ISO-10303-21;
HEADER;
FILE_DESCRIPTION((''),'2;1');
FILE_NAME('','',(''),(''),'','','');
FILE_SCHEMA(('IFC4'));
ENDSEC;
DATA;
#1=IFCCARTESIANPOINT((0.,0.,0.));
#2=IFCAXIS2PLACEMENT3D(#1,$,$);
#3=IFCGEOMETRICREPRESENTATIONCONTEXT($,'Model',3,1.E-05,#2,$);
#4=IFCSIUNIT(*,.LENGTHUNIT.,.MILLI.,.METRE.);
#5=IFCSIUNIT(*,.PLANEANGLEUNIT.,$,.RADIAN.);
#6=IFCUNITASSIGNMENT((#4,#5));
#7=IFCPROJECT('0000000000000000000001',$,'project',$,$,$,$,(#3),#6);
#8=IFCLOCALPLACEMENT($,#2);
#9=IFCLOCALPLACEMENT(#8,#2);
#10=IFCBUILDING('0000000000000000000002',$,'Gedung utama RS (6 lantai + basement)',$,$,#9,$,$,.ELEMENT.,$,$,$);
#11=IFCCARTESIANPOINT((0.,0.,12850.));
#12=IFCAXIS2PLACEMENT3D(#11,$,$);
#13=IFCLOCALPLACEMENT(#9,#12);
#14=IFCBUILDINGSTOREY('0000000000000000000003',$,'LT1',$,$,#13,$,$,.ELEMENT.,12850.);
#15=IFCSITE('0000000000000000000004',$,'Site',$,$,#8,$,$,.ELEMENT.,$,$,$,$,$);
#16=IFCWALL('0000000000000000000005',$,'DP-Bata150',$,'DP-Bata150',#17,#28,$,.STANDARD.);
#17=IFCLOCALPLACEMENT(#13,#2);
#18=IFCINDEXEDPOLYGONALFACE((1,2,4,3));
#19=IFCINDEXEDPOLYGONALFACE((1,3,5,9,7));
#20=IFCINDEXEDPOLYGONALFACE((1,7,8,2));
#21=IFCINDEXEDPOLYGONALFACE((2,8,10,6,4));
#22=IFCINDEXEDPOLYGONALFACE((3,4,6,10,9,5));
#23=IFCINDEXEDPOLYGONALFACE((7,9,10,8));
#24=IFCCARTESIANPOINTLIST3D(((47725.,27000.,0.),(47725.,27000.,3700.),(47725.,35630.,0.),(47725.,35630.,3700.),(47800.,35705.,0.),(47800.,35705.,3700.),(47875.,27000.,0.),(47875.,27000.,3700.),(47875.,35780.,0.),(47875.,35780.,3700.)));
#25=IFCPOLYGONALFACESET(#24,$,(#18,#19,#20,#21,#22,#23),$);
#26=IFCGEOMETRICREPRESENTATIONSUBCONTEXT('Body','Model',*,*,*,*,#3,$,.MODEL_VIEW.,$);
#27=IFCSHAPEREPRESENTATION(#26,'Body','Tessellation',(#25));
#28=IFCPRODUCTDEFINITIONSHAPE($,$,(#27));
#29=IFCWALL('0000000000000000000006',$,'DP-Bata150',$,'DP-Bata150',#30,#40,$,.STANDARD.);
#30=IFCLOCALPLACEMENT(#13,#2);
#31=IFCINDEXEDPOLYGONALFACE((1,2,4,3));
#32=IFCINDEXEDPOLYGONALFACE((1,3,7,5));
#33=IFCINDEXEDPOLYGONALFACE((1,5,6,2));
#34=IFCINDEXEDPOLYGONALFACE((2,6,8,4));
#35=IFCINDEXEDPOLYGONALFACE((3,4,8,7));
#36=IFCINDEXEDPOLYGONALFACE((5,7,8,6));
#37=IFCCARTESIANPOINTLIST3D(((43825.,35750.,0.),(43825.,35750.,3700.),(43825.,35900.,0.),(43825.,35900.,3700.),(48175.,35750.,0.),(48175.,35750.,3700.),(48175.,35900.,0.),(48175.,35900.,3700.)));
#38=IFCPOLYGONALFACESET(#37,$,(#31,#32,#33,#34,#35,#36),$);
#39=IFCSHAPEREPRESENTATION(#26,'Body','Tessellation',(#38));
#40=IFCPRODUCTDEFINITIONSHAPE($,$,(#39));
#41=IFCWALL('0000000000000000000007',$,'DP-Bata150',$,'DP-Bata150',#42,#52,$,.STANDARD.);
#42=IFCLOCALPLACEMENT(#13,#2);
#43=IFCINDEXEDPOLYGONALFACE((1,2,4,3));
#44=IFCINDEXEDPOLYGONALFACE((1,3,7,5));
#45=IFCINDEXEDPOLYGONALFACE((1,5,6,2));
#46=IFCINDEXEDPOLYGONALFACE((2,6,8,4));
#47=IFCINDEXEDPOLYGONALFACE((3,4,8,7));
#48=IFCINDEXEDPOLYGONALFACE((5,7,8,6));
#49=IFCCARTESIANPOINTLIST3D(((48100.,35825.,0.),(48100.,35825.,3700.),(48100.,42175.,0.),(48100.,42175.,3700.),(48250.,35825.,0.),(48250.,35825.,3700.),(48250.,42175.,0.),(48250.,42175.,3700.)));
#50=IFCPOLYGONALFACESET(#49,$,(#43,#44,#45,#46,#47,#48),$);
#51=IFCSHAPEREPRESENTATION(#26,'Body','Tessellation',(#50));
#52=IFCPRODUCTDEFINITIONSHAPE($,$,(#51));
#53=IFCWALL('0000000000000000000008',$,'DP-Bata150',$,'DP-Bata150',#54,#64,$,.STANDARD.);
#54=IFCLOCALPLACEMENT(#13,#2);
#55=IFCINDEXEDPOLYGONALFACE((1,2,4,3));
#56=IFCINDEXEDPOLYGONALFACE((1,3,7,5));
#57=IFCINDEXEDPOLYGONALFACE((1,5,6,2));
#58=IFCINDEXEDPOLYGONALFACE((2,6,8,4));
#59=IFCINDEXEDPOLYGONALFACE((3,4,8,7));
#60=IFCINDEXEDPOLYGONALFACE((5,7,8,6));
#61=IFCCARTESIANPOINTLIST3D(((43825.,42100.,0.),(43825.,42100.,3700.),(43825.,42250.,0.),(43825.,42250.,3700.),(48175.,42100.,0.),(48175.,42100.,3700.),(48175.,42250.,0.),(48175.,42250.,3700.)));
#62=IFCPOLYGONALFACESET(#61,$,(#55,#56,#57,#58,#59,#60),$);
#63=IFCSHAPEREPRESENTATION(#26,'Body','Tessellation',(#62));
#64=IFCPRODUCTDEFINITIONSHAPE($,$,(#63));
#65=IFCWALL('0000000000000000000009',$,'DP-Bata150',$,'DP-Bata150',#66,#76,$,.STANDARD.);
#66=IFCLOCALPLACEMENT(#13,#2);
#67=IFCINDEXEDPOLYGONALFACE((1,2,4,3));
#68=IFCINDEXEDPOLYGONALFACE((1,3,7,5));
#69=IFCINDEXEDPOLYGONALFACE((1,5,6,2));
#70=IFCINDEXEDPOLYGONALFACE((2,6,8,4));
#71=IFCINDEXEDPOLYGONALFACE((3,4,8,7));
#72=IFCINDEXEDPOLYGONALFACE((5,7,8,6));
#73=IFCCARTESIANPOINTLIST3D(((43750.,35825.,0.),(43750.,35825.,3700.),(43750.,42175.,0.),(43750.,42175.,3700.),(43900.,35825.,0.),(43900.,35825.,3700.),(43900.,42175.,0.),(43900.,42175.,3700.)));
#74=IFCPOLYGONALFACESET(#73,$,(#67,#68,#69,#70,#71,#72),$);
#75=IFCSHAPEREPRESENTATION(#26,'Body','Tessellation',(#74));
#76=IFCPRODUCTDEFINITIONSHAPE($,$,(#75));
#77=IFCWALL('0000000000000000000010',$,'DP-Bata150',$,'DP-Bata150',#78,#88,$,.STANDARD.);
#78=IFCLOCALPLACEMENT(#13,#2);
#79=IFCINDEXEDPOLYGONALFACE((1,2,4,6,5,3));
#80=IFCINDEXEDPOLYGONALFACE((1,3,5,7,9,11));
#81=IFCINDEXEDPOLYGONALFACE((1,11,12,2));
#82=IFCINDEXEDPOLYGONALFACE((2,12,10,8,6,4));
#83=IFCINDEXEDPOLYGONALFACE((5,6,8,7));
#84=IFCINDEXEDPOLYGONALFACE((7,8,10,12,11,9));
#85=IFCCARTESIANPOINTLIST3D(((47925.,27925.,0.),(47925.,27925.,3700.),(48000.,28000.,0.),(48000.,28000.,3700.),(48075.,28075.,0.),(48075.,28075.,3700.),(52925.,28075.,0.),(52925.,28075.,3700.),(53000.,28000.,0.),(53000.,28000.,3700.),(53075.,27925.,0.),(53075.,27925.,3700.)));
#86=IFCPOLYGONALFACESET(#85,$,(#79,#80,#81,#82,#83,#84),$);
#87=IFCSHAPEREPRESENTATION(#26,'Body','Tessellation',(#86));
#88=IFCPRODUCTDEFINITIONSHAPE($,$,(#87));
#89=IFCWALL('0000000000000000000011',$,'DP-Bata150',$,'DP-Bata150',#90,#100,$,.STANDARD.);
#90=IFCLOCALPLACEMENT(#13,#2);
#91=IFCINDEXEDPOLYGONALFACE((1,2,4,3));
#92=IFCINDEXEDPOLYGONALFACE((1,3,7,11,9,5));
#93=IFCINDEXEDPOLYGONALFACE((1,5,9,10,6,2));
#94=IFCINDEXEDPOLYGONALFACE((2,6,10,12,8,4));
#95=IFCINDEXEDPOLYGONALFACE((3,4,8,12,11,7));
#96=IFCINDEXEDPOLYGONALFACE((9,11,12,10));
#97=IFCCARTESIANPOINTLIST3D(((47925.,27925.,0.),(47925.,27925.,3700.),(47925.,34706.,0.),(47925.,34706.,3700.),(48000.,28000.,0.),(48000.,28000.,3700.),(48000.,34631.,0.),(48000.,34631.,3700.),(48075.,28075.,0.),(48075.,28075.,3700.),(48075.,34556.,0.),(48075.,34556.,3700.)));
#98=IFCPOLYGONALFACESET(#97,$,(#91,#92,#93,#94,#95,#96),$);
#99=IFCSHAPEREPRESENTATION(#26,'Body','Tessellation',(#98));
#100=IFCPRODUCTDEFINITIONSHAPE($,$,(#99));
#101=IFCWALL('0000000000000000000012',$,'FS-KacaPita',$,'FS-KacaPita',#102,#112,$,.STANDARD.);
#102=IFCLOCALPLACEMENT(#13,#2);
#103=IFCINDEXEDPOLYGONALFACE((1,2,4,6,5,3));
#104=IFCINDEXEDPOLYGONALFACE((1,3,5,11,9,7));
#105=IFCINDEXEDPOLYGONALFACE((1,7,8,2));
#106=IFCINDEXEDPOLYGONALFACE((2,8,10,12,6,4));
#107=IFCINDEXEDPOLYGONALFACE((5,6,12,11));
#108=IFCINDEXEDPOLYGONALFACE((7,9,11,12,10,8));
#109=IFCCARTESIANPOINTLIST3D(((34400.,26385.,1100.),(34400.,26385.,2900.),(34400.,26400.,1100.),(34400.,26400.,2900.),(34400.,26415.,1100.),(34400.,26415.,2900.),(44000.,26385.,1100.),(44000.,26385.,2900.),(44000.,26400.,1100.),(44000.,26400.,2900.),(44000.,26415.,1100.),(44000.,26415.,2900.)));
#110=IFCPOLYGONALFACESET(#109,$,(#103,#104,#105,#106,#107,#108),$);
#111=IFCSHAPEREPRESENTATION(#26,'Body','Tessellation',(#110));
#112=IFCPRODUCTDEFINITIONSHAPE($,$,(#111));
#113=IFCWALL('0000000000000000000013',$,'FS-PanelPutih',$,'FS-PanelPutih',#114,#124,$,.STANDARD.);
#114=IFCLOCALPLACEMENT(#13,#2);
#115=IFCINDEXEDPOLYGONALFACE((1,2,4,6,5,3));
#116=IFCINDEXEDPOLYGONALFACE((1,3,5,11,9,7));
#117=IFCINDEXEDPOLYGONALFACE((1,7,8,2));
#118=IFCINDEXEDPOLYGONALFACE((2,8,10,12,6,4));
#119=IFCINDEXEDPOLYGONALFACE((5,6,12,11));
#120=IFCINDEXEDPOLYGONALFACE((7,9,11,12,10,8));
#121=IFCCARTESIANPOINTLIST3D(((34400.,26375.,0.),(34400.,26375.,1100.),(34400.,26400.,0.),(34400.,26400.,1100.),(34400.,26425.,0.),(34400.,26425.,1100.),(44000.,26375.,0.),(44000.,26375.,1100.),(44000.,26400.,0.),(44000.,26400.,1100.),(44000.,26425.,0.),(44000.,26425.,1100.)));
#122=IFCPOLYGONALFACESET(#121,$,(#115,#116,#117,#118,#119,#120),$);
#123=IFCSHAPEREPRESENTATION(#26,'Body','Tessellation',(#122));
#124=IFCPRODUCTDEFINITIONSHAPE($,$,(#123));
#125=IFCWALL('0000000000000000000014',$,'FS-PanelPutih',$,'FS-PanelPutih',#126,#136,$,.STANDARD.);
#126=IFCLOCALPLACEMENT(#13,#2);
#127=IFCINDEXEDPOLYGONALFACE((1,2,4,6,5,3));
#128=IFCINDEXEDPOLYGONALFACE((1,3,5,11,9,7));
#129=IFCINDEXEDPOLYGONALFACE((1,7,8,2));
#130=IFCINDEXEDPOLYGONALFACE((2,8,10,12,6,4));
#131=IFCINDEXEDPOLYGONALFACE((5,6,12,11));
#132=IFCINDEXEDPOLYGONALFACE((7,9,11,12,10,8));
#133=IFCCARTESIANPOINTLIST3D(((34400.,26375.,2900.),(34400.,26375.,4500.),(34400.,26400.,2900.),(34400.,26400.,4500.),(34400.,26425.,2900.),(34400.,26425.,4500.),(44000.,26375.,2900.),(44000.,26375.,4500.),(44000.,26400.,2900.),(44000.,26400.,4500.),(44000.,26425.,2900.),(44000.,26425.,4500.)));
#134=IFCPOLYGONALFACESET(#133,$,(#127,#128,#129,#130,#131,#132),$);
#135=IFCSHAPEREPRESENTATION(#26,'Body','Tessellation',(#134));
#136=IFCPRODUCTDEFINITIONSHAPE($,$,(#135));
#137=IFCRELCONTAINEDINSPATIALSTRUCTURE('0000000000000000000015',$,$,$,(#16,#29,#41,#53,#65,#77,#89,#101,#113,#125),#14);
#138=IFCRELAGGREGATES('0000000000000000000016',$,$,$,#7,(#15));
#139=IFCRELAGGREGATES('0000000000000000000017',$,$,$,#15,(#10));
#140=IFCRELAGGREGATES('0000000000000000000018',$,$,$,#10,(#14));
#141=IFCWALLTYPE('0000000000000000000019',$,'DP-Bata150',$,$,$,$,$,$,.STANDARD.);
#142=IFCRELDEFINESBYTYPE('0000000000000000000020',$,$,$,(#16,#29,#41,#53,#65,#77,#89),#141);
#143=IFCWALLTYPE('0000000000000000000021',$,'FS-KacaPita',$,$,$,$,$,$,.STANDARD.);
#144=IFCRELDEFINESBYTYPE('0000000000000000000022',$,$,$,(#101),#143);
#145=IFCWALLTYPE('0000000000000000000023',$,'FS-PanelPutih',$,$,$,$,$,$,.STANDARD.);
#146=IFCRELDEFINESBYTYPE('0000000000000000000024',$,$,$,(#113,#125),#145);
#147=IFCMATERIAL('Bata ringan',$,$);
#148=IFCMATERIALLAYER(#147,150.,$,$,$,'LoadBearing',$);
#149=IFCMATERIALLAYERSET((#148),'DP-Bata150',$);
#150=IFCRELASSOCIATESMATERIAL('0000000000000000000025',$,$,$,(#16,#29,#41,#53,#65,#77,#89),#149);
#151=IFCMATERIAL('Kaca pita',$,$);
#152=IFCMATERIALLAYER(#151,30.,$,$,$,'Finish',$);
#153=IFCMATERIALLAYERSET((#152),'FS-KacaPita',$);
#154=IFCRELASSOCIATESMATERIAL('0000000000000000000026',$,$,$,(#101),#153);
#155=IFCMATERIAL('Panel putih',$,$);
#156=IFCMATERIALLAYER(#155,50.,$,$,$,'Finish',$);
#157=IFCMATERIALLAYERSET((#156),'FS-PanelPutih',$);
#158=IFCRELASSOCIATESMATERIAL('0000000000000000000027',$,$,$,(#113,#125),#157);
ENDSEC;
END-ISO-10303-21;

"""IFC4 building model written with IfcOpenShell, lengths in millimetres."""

from ifc_helpers import new_model, si_unit, frame, origin, place, context, subcontext, project, spatial, polyline, outline, extrude, material, layer, layer_set, layer_usage, type_object, element, save


model = new_model("IFC4")

# Units and contexts
model_context = context("Model", 3, precision=1e-05, world=origin())
body_context = subcontext(model_context, "Body", "Model", "MODEL_VIEW")
ifc_project = project(units=[si_unit("LENGTHUNIT", "METRE", prefix="MILLI"), si_unit("PLANEANGLEUNIT", "RADIAN")], contexts=[model_context])

# Site, building, storey
site_placement = place(None, origin())
site = spatial("IfcSite", under=ifc_project, at=site_placement, Name="Site", CompositionType="ELEMENT")
building_placement = place(site_placement, origin())
building = spatial("IfcBuilding", under=site, at=building_placement, Name="Gedung utama RS (6 lantai + basement)", CompositionType="ELEMENT")
storey_placement = place(building_placement, frame((0.0, 0.0, 12850.0)))
storey = spatial("IfcBuildingStorey", under=building, at=storey_placement, Name="LT1", CompositionType="ELEMENT", Elevation=12850.0)

# Shared definitions
ifc_material_1 = material(Name="Bata ringan")
ifc_layer_1 = layer(ifc_material_1, 150.0, Category="LoadBearing")
ifc_layer_set_1 = layer_set([ifc_layer_1], Name="DP-Bata150")
ifc_layer_usage_1 = layer_usage(ifc_layer_set_1, "AXIS2", "NEGATIVE", 75.0)
wall_type_1 = type_object("IfcWallType", Name="DP-Bata150", PredefinedType="STANDARD")

# Walls
wall_1_placement = place(storey_placement, frame((47800.0, 35705.0, 0.0), z_axis=(0.0, 0.0, 1.0), x_axis=(0.0, -1.0, 0.0)))
element("IfcWall", 1, at=wall_1_placement, inside=storey, type_object=wall_type_1, material=ifc_layer_usage_1, Name="DP-Bata150", ObjectType="DP-Bata150", PredefinedType="STANDARD", context=body_context, shape_type="SweptSolid", body=[
    extrude(outline(polyline([(75.0, -75.0), (0.0, 0.0), (-75.0, 75.0), (8705.0, 75.0), (8705.0, -75.0), (75.0, -75.0)])), origin(), (0.0, 0.0, 1.0), 3700.0),
])
wall_2_placement = place(storey_placement, frame((43825.0, 35825.0, 0.0), z_axis=(0.0, 0.0, 1.0), x_axis=(1.0, 0.0, 0.0)))
element("IfcWall", 2, at=wall_2_placement, inside=storey, type_object=wall_type_1, material=ifc_layer_usage_1, Name="DP-Bata150", ObjectType="DP-Bata150", PredefinedType="STANDARD", context=body_context, shape_type="SweptSolid", body=[
    extrude(outline(polyline([(0.0, -75.0), (0.0, 75.0), (4350.0, 75.0), (4350.0, -75.0), (0.0, -75.0)])), origin(), (0.0, 0.0, 1.0), 3700.0),
])
wall_3_placement = place(storey_placement, frame((48175.0, 35825.0, 0.0), z_axis=(0.0, 0.0, 1.0), x_axis=(0.0, 1.0, 0.0)))
element("IfcWall", 3, at=wall_3_placement, inside=storey, type_object=wall_type_1, material=ifc_layer_usage_1, Name="DP-Bata150", ObjectType="DP-Bata150", PredefinedType="STANDARD", context=body_context, shape_type="SweptSolid", body=[
    extrude(outline(polyline([(0.0, -75.0), (0.0, 75.0), (6350.0, 75.0), (6350.0, -75.0), (0.0, -75.0)])), origin(), (0.0, 0.0, 1.0), 3700.0),
])
wall_4_placement = place(storey_placement, frame((48175.0, 42175.0, 0.0), z_axis=(0.0, 0.0, 1.0), x_axis=(-1.0, 0.0, 0.0)))
element("IfcWall", 4, at=wall_4_placement, inside=storey, type_object=wall_type_1, material=ifc_layer_usage_1, Name="DP-Bata150", ObjectType="DP-Bata150", PredefinedType="STANDARD", context=body_context, shape_type="SweptSolid", body=[
    extrude(outline(polyline([(0.0, -75.0), (0.0, 75.0), (4350.0, 75.0), (4350.0, -75.0), (0.0, -75.0)])), origin(), (0.0, 0.0, 1.0), 3700.0),
])
wall_5_placement = place(storey_placement, frame((43825.0, 42175.0, 0.0), z_axis=(0.0, 0.0, 1.0), x_axis=(0.0, -1.0, 0.0)))
element("IfcWall", 5, at=wall_5_placement, inside=storey, type_object=wall_type_1, material=ifc_layer_usage_1, Name="DP-Bata150", ObjectType="DP-Bata150", PredefinedType="STANDARD", context=body_context, shape_type="SweptSolid", body=[
    extrude(outline(polyline([(0.0, -75.0), (0.0, 75.0), (6350.0, 75.0), (6350.0, -75.0), (0.0, -75.0)])), origin(), (0.0, 0.0, 1.0), 3700.0),
])
wall_6_placement = place(storey_placement, frame((48000.0, 28000.0, 0.0), z_axis=(0.0, 0.0, 1.0), x_axis=(1.0, 0.0, 0.0)))
element("IfcWall", 6, at=wall_6_placement, inside=storey, type_object=wall_type_1, material=ifc_layer_usage_1, Name="DP-Bata150", ObjectType="DP-Bata150", PredefinedType="STANDARD", context=body_context, shape_type="SweptSolid", body=[
    extrude(outline(polyline([(-75.0, -75.0), (0.0, 0.0), (75.0, 75.0), (4925.0, 75.0), (5000.0, 0.0), (5075.0, -75.0), (-75.0, -75.0)])), origin(), (0.0, 0.0, 1.0), 3700.0),
])
wall_7_placement = place(storey_placement, frame((48000.0, 34631.0, 0.0), z_axis=(0.0, 0.0, 1.0), x_axis=(0.0, -1.0, 0.0)))
element("IfcWall", 7, at=wall_7_placement, inside=storey, type_object=wall_type_1, material=ifc_layer_usage_1, Name="DP-Bata150", ObjectType="DP-Bata150", PredefinedType="STANDARD", context=body_context, shape_type="SweptSolid", body=[
    extrude(outline(polyline([(-75.0, -75.0), (0.0, 0.0), (75.0, 75.0), (6556.0, 75.0), (6631.0, 0.0), (6706.0, -75.0), (-75.0, -75.0)])), origin(), (0.0, 0.0, 1.0), 3700.0),
])
ifc_material_2 = material(Name="Kaca pita")
ifc_layer_2 = layer(ifc_material_2, 30.0, Category="Finish")
ifc_layer_set_2 = layer_set([ifc_layer_2], Name="FS-KacaPita")
ifc_layer_usage_2 = layer_usage(ifc_layer_set_2, "AXIS2", "NEGATIVE", 15.0)
wall_type_2 = type_object("IfcWallType", Name="FS-KacaPita", PredefinedType="STANDARD")
wall_8_placement = place(storey_placement, frame((44000.0, 26400.0, 1100.0), z_axis=(0.0, 0.0, 1.0), x_axis=(-1.0, 0.0, 0.0)))
element("IfcWall", 8, at=wall_8_placement, inside=storey, type_object=wall_type_2, material=ifc_layer_usage_2, Name="FS-KacaPita", ObjectType="FS-KacaPita", PredefinedType="STANDARD", context=body_context, shape_type="SweptSolid", body=[
    extrude(outline(polyline([(0.0, -15.0), (0.0, 0.0), (0.0, 15.0), (9600.0, 15.0), (9600.0, 0.0), (9600.0, -15.0), (0.0, -15.0)])), origin(), (0.0, 0.0, 1.0), 1800.0),
])
ifc_material_3 = material(Name="Panel putih")
ifc_layer_3 = layer(ifc_material_3, 50.0, Category="Finish")
ifc_layer_set_3 = layer_set([ifc_layer_3], Name="FS-PanelPutih")
ifc_layer_usage_3 = layer_usage(ifc_layer_set_3, "AXIS2", "NEGATIVE", 25.0)
wall_type_3 = type_object("IfcWallType", Name="FS-PanelPutih", PredefinedType="STANDARD")
wall_9_placement = place(storey_placement, frame((44000.0, 26400.0, 0.0), z_axis=(0.0, 0.0, 1.0), x_axis=(-1.0, 0.0, 0.0)))
element("IfcWall", 9, at=wall_9_placement, inside=storey, type_object=wall_type_3, material=ifc_layer_usage_3, Name="FS-PanelPutih", ObjectType="FS-PanelPutih", PredefinedType="STANDARD", context=body_context, shape_type="SweptSolid", body=[
    extrude(outline(polyline([(0.0, -25.0), (0.0, 0.0), (0.0, 25.0), (9600.0, 25.0), (9600.0, 0.0), (9600.0, -25.0), (0.0, -25.0)])), origin(), (0.0, 0.0, 1.0), 1100.0),
])
wall_10_placement = place(storey_placement, frame((44000.0, 26400.0, 2900.0), z_axis=(0.0, 0.0, 1.0), x_axis=(-1.0, 0.0, 0.0)))
element("IfcWall", 10, at=wall_10_placement, inside=storey, type_object=wall_type_3, material=ifc_layer_usage_3, Name="FS-PanelPutih", ObjectType="FS-PanelPutih", PredefinedType="STANDARD", context=body_context, shape_type="SweptSolid", body=[
    extrude(outline(polyline([(0.0, -25.0), (0.0, 0.0), (0.0, 25.0), (9600.0, 25.0), (9600.0, 0.0), (9600.0, -25.0), (0.0, -25.0)])), origin(), (0.0, 0.0, 1.0), 1600.0),
])

save(model, "model.ifc")
